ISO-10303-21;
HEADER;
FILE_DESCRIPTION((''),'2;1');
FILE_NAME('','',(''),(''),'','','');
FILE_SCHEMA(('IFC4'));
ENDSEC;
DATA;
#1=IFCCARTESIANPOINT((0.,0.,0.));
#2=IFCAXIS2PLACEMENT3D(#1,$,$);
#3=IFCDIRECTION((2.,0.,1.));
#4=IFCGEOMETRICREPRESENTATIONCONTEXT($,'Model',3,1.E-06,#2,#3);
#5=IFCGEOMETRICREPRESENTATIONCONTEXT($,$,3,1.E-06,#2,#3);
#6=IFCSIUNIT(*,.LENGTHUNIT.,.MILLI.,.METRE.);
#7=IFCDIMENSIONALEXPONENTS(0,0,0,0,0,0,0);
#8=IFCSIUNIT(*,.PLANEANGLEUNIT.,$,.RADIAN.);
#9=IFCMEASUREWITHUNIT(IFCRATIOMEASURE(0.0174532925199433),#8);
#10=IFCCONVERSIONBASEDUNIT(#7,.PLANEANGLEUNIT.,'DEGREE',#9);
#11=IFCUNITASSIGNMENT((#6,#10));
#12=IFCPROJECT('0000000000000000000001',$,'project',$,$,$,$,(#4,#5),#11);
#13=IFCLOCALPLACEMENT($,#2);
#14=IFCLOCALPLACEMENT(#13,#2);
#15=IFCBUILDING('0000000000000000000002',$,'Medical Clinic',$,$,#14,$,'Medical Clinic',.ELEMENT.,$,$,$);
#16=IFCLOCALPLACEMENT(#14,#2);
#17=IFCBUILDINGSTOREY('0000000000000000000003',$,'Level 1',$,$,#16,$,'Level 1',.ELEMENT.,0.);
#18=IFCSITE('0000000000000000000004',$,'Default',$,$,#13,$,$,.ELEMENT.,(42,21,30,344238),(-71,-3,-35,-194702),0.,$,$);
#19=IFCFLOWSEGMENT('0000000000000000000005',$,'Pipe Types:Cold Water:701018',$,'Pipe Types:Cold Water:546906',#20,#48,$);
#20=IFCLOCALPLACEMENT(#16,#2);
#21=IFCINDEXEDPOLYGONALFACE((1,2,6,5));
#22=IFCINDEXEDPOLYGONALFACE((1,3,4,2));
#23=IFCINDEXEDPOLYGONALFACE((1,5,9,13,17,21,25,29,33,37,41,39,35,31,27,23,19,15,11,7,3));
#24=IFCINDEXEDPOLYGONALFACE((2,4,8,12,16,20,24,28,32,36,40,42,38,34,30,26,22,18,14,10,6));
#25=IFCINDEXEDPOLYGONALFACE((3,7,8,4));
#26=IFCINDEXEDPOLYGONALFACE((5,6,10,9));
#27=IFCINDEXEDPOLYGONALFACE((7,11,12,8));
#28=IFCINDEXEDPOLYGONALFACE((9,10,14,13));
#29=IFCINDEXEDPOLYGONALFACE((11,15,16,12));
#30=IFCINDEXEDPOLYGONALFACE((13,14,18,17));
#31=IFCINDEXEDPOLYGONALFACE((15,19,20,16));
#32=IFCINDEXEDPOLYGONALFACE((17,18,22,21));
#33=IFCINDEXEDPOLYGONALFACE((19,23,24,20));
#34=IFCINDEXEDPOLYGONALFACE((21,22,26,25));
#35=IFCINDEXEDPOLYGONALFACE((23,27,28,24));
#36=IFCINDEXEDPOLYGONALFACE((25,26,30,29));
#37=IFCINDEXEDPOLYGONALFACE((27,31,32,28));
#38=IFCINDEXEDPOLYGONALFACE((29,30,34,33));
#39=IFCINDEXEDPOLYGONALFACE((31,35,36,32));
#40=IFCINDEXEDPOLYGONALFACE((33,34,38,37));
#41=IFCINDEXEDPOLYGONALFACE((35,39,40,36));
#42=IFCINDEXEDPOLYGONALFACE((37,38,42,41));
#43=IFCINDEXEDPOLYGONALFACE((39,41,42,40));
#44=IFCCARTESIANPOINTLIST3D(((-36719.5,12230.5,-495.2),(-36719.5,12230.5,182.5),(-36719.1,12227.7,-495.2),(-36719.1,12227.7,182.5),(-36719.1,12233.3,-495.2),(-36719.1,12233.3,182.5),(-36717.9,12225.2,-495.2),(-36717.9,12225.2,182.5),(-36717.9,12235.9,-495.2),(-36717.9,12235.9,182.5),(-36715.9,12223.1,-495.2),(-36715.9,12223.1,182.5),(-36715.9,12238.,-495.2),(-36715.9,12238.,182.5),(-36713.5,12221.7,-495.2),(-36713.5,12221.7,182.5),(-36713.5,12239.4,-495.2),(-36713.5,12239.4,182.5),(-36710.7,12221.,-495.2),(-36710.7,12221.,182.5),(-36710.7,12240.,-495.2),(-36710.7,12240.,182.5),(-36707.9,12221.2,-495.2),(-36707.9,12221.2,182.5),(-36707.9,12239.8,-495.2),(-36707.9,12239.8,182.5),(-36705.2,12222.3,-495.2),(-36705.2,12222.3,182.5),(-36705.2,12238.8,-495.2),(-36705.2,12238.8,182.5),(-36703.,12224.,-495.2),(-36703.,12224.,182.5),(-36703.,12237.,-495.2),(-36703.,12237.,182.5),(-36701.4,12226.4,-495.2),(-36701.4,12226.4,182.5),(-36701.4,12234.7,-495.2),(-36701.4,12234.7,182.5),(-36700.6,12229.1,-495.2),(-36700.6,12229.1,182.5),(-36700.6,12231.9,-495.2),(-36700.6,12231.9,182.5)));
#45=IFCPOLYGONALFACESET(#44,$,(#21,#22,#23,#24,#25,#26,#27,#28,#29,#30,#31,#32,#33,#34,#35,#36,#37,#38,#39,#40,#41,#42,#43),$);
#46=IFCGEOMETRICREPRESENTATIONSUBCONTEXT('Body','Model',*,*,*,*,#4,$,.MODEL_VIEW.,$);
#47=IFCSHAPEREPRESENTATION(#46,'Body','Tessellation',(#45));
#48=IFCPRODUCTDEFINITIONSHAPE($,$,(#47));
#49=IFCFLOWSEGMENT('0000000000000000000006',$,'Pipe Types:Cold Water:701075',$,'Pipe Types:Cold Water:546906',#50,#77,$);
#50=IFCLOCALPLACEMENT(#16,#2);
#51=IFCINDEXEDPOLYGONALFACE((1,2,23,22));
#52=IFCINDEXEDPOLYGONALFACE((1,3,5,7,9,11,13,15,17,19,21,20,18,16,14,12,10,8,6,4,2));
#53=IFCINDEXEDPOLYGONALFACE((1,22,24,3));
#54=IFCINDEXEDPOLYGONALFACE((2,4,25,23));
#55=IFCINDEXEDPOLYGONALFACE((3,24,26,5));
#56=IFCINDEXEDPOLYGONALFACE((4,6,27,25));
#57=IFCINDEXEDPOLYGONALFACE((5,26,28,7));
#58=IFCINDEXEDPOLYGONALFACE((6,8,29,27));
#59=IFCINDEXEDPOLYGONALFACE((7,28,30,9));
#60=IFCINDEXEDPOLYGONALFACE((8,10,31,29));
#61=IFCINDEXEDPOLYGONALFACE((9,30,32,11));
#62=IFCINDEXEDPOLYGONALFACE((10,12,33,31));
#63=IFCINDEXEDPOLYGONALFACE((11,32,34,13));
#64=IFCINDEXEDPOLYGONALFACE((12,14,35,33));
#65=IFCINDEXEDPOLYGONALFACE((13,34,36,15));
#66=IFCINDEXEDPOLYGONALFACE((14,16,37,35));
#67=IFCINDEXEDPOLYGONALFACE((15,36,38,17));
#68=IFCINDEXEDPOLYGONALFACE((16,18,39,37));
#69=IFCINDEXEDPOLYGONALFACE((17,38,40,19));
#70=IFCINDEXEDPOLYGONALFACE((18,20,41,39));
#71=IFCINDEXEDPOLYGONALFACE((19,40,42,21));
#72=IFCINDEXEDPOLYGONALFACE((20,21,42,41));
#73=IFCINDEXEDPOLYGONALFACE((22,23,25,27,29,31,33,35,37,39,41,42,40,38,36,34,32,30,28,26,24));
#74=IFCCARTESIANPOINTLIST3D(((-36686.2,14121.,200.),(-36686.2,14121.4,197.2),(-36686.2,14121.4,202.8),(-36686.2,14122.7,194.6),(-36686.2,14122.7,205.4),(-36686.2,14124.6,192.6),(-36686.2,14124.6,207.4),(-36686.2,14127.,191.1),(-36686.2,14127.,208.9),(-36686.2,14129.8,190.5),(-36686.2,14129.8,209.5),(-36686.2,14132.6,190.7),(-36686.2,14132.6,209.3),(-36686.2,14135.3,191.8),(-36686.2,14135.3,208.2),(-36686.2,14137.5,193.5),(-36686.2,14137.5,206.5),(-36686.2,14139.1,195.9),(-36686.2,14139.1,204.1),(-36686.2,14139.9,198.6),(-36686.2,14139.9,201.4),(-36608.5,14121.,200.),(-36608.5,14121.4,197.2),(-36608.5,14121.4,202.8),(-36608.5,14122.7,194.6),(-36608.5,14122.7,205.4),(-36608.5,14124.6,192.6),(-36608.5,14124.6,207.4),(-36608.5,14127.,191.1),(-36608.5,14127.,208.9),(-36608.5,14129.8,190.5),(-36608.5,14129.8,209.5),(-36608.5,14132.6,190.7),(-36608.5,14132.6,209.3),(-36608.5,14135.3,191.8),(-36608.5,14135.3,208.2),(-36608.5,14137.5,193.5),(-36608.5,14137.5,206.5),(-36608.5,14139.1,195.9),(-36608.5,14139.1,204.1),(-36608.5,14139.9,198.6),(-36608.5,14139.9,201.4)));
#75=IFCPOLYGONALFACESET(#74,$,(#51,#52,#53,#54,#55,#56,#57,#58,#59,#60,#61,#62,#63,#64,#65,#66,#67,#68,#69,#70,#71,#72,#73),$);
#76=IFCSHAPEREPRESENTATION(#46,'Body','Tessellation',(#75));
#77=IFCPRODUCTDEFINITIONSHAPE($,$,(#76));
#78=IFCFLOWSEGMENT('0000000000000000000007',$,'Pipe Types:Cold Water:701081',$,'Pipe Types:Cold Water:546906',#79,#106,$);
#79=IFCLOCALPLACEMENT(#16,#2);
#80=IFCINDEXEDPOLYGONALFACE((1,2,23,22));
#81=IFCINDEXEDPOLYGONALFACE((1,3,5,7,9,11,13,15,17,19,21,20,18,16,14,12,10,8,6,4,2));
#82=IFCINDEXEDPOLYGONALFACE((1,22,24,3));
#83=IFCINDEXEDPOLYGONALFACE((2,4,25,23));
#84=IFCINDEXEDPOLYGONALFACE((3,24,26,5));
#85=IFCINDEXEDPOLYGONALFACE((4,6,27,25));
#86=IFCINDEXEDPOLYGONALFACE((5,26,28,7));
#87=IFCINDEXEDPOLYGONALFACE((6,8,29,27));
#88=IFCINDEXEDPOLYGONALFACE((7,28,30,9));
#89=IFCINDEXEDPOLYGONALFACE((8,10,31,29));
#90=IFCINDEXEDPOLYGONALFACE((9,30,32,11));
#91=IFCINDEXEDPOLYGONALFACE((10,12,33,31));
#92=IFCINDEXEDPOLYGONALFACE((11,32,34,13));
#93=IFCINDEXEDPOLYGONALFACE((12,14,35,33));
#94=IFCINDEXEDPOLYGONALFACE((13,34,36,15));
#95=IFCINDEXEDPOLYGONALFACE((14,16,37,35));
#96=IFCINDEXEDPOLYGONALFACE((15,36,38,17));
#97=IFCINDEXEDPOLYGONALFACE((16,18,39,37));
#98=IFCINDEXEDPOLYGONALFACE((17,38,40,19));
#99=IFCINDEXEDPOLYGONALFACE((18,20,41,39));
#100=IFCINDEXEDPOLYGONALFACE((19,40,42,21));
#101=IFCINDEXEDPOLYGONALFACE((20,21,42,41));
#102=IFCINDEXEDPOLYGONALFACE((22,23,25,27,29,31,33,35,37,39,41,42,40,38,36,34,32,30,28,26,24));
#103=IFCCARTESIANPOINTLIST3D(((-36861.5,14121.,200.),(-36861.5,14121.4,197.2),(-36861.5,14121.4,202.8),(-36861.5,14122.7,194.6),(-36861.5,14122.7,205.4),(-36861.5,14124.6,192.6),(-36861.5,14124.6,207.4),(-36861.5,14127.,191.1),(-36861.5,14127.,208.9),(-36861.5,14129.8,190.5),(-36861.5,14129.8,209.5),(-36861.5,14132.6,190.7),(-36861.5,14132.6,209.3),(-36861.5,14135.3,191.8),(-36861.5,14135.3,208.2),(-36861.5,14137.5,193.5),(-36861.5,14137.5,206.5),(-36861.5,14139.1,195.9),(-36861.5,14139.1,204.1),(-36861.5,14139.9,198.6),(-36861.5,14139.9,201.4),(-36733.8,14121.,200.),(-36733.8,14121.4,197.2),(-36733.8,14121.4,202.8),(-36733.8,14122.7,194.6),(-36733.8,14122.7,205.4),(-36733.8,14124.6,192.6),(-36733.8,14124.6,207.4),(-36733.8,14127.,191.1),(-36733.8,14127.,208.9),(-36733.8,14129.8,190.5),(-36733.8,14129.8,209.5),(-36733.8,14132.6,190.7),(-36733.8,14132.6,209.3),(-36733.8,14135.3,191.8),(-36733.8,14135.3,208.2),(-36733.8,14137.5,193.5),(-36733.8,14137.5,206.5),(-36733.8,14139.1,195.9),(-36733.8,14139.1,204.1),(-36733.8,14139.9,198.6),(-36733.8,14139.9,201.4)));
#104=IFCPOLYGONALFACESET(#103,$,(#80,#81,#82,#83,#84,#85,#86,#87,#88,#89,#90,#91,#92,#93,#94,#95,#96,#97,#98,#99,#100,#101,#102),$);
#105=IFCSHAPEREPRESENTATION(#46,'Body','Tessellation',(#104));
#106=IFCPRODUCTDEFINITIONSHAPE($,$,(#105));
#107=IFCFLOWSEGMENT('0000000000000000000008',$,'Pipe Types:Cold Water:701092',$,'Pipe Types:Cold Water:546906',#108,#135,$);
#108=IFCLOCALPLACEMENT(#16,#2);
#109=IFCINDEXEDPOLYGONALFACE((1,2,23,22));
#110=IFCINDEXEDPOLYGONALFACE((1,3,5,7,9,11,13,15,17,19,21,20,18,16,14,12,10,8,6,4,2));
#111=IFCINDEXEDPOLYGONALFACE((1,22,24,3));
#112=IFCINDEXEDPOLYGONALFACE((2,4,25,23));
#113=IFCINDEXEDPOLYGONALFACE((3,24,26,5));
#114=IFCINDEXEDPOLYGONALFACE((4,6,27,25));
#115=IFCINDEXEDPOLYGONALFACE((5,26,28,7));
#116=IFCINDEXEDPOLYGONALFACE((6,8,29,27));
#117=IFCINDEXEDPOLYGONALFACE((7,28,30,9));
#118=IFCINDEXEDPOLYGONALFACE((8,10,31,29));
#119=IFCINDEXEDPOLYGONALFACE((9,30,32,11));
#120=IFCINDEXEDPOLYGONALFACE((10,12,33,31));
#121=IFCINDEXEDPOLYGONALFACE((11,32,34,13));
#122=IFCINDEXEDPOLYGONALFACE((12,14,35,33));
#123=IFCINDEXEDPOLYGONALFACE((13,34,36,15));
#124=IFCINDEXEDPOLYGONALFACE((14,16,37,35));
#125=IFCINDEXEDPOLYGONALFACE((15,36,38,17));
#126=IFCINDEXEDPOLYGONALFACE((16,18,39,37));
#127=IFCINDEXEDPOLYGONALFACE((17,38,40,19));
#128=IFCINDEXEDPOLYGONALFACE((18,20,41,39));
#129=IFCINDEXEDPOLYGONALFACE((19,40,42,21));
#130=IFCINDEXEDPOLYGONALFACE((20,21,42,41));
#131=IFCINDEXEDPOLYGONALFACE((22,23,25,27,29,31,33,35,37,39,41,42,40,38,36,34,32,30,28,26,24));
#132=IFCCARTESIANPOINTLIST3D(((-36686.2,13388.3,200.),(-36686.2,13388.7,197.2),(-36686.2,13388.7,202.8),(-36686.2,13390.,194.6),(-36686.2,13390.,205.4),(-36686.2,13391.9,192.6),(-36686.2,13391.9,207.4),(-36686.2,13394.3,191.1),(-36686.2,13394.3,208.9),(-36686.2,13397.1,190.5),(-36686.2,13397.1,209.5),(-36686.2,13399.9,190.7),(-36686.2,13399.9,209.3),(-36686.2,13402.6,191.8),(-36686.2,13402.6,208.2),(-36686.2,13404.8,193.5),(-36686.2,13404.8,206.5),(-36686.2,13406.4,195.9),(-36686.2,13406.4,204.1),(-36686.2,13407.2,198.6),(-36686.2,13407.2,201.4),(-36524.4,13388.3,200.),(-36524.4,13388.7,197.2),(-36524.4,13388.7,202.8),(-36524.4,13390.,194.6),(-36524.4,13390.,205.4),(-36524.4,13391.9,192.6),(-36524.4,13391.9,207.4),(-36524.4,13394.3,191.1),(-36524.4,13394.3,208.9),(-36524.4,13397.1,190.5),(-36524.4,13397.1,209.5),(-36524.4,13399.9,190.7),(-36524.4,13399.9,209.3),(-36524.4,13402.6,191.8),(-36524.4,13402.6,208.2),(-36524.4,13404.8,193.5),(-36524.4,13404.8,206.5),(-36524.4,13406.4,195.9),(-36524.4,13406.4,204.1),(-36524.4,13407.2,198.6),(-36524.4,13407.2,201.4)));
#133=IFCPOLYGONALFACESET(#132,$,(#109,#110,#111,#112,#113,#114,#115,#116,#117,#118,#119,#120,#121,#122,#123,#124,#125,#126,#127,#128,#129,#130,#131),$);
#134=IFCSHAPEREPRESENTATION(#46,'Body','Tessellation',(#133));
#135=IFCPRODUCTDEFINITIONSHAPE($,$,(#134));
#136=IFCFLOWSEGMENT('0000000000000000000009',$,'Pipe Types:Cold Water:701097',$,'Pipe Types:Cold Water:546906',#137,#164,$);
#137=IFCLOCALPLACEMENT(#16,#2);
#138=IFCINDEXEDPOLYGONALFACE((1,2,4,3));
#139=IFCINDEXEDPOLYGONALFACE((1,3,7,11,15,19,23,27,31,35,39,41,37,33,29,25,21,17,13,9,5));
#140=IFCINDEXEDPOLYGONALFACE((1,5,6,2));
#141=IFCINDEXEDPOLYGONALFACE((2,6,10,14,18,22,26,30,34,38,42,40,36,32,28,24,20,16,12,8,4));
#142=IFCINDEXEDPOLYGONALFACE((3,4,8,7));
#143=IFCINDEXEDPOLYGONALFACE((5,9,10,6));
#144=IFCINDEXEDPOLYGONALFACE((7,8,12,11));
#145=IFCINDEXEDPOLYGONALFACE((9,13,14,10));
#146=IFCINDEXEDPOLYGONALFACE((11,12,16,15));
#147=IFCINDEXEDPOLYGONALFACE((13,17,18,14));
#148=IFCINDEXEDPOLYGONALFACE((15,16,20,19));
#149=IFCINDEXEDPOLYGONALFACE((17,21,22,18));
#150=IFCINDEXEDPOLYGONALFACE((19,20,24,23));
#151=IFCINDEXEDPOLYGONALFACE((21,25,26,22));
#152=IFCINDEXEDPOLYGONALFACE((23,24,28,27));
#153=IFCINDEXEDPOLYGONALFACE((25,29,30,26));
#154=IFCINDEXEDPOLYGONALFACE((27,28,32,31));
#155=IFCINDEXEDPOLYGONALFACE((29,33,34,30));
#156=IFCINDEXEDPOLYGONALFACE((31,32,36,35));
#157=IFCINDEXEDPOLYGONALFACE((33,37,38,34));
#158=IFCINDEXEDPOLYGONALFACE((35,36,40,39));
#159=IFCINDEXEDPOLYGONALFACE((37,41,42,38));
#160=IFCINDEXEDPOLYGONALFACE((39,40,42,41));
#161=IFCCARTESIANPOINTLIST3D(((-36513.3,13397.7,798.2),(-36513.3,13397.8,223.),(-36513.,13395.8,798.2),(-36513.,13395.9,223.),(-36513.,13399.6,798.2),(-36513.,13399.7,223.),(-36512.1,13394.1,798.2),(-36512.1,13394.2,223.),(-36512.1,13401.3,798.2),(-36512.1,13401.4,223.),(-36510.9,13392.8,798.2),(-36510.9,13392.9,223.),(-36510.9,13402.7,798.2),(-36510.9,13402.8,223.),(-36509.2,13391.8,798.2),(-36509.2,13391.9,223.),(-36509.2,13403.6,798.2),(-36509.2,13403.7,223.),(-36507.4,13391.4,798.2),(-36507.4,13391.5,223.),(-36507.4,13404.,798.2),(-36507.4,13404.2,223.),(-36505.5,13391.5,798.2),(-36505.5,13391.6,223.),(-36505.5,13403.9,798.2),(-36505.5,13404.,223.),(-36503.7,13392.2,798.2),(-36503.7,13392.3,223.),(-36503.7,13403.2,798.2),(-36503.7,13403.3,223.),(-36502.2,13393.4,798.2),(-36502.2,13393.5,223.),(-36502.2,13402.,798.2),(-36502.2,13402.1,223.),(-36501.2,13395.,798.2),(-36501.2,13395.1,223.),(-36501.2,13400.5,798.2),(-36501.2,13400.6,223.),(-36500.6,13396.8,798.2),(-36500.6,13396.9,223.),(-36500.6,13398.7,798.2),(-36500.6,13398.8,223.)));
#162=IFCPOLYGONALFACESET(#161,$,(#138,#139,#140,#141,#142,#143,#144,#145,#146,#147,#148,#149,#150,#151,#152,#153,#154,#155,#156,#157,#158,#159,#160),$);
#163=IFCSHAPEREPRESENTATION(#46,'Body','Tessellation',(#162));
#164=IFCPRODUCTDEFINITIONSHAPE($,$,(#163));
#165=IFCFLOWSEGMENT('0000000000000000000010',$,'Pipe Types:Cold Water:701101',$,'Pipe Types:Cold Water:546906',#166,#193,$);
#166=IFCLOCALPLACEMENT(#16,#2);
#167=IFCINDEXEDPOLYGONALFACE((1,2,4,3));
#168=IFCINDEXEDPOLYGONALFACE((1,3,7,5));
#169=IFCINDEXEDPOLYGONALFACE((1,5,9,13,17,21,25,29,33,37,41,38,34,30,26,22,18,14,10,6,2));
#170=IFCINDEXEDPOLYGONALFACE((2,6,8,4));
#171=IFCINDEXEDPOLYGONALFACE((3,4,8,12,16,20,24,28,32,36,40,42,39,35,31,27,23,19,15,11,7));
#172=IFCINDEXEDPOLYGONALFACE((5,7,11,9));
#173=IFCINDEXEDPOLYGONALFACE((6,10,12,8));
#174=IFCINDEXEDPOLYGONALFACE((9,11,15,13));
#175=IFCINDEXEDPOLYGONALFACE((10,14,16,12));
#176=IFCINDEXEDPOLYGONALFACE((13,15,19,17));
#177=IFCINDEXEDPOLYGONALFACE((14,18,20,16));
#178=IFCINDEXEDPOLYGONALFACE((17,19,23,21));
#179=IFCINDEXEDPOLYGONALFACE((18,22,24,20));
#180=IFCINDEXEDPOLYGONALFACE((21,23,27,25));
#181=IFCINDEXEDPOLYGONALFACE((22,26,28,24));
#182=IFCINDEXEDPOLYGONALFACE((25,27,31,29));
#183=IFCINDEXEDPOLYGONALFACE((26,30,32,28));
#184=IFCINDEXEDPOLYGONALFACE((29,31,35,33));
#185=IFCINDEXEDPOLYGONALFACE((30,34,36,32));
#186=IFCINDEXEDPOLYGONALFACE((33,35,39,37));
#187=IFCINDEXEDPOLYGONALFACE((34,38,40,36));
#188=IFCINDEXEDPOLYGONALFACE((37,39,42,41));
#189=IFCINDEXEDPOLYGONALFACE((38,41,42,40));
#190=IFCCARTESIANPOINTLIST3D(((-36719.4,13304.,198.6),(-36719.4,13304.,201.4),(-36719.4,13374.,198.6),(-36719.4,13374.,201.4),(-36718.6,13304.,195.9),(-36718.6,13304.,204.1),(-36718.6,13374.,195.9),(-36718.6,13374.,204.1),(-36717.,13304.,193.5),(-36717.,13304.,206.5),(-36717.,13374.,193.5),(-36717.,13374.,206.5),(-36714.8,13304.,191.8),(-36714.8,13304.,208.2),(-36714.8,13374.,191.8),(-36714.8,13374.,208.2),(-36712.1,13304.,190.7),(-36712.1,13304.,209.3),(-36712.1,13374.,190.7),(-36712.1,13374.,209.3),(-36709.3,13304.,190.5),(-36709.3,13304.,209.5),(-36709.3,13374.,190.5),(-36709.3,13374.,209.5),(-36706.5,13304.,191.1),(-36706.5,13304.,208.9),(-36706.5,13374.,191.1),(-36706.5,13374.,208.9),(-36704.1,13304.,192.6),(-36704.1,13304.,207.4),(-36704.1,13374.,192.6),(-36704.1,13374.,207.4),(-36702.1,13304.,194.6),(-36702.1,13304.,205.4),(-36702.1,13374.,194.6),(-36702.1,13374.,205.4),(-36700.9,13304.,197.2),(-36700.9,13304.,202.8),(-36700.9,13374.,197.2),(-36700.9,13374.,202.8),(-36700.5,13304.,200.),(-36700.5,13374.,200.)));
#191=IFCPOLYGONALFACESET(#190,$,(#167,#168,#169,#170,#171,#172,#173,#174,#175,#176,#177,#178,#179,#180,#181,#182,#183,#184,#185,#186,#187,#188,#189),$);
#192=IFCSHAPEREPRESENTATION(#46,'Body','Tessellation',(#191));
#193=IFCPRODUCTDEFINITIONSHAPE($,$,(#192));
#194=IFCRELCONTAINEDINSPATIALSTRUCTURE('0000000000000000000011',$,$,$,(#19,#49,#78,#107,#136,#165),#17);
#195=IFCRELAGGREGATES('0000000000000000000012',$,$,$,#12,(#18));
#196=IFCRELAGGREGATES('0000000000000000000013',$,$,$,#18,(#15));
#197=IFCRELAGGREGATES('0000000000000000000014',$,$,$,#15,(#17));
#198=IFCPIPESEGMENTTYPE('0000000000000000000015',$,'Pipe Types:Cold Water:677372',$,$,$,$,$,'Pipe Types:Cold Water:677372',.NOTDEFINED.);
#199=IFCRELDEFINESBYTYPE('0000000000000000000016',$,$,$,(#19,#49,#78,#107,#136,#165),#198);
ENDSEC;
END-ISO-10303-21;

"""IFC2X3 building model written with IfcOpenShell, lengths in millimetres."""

from ifc_helpers import new_model, entity, si_unit, converted_unit, direction, frame, origin, origin_2d_with_axis, place, context, subcontext, project, spatial, circle, extrude, type_object, element, save


model = new_model("IFC2X3")

# Units and contexts
model_context = context("Model", 3, precision=1e-06, world=origin(), true_north=direction((2.0, 0.0, 1.0)))
context_of_model = context(None, 3, precision=1e-06, world=origin(), true_north=direction((2.0, 0.0, 1.0)))
body_context = subcontext(model_context, "Body", "Model", "MODEL_VIEW")
ifc_project = project(units=[si_unit("LENGTHUNIT", "METRE", prefix="MILLI"), converted_unit("PLANEANGLEUNIT", "DEGREE", entity("IfcRatioMeasure", 0.0174532925199433), si_unit("PLANEANGLEUNIT", "RADIAN"), dimensions=[0, 0, 0, 0, 0, 0, 0])], contexts=[model_context, context_of_model])

# Site, building, storey
site_placement = place(None, origin())
site = spatial("IfcSite", under=ifc_project, at=site_placement, Name="Default", CompositionType="ELEMENT", RefLatitude=(42, 21, 30, 344238), RefLongitude=(-71, -3, -35, -194702), RefElevation=0.0)
building_placement = place(site_placement, origin())
building = spatial("IfcBuilding", under=site, at=building_placement, Name="Medical Clinic", LongName="Medical Clinic", CompositionType="ELEMENT")
storey_placement = place(building_placement, origin())
storey = spatial("IfcBuildingStorey", under=building, at=storey_placement, Name="Level 1", LongName="Level 1", CompositionType="ELEMENT", Elevation=0.0)

# Flow segments
pipe_segment_type_1 = type_object("IfcPipeSegmentType", Name="Pipe Types:Cold Water:677372", ElementType="Pipe Types:Cold Water:677372", PredefinedType="NOTDEFINED")
flow_segment_1_placement = place(storey_placement, origin())
element("IfcFlowSegment", 1, at=flow_segment_1_placement, inside=storey, type_object=pipe_segment_type_1, Name="Pipe Types:Cold Water:701018", ObjectType="Pipe Types:Cold Water:546906", context=body_context, shape_type="SweptSolid", body=[
    extrude(circle(Radius=9.5, at=origin_2d_with_axis()), frame((-36710.0, 12230.5, -495.2), z_axis=(0.0, 0.0, 1.0), x_axis=(-1.0, 0.0, 0.0)), (0.0, 0.0, 1.0), 677.8),
])
flow_segment_2_placement = place(storey_placement, origin())
element("IfcFlowSegment", 2, at=flow_segment_2_placement, inside=storey, type_object=pipe_segment_type_1, Name="Pipe Types:Cold Water:701075", ObjectType="Pipe Types:Cold Water:546906", context=body_context, shape_type="SweptSolid", body=[
    extrude(circle(Radius=9.5, at=origin_2d_with_axis()), frame((-36686.2, 14130.5, 200.0), z_axis=(1.0, 0.0, 0.0), x_axis=(0.0, -1.0, 0.0)), (0.0, 0.0, 1.0), 77.7),
])
flow_segment_3_placement = place(storey_placement, origin())
element("IfcFlowSegment", 3, at=flow_segment_3_placement, inside=storey, type_object=pipe_segment_type_1, Name="Pipe Types:Cold Water:701081", ObjectType="Pipe Types:Cold Water:546906", context=body_context, shape_type="SweptSolid", body=[
    extrude(circle(Radius=9.5, at=origin_2d_with_axis()), frame((-36861.5, 14130.5, 200.0), z_axis=(1.0, 0.0, 0.0), x_axis=(0.0, -1.0, 0.0)), (0.0, 0.0, 1.0), 127.7),
])
flow_segment_4_placement = place(storey_placement, origin())
element("IfcFlowSegment", 4, at=flow_segment_4_placement, inside=storey, type_object=pipe_segment_type_1, Name="Pipe Types:Cold Water:701092", ObjectType="Pipe Types:Cold Water:546906", context=body_context, shape_type="SweptSolid", body=[
    extrude(circle(Radius=9.5, at=origin_2d_with_axis()), frame((-36686.2, 13397.8, 200.0), z_axis=(1.0, 0.0, 0.0), x_axis=(0.0, -1.0, 0.0)), (0.0, 0.0, 1.0), 161.8),
])
flow_segment_5_placement = place(storey_placement, origin())
element("IfcFlowSegment", 5, at=flow_segment_5_placement, inside=storey, type_object=pipe_segment_type_1, Name="Pipe Types:Cold Water:701097", ObjectType="Pipe Types:Cold Water:546906", context=body_context, shape_type="SweptSolid", body=[
    extrude(circle(Radius=6.3, at=origin_2d_with_axis()), frame((-36506.9, 13397.8, 223.0), z_axis=(0.0, -0.000175, 1.0), x_axis=(-1.0, 0.0, 0.0)), (0.0, 0.0, 1.0), 575.2),
])
flow_segment_6_placement = place(storey_placement, origin())
element("IfcFlowSegment", 6, at=flow_segment_6_placement, inside=storey, type_object=pipe_segment_type_1, Name="Pipe Types:Cold Water:701101", ObjectType="Pipe Types:Cold Water:546906", context=body_context, shape_type="SweptSolid", body=[
    extrude(circle(Radius=9.5, at=origin_2d_with_axis()), frame((-36710.0, 13304.0, 200.0), z_axis=(0.0, 1.0, 0.0), x_axis=(1.0, 0.0, 0.0)), (0.0, 0.0, 1.0), 70.0),
])

save(model, "model.ifc")
